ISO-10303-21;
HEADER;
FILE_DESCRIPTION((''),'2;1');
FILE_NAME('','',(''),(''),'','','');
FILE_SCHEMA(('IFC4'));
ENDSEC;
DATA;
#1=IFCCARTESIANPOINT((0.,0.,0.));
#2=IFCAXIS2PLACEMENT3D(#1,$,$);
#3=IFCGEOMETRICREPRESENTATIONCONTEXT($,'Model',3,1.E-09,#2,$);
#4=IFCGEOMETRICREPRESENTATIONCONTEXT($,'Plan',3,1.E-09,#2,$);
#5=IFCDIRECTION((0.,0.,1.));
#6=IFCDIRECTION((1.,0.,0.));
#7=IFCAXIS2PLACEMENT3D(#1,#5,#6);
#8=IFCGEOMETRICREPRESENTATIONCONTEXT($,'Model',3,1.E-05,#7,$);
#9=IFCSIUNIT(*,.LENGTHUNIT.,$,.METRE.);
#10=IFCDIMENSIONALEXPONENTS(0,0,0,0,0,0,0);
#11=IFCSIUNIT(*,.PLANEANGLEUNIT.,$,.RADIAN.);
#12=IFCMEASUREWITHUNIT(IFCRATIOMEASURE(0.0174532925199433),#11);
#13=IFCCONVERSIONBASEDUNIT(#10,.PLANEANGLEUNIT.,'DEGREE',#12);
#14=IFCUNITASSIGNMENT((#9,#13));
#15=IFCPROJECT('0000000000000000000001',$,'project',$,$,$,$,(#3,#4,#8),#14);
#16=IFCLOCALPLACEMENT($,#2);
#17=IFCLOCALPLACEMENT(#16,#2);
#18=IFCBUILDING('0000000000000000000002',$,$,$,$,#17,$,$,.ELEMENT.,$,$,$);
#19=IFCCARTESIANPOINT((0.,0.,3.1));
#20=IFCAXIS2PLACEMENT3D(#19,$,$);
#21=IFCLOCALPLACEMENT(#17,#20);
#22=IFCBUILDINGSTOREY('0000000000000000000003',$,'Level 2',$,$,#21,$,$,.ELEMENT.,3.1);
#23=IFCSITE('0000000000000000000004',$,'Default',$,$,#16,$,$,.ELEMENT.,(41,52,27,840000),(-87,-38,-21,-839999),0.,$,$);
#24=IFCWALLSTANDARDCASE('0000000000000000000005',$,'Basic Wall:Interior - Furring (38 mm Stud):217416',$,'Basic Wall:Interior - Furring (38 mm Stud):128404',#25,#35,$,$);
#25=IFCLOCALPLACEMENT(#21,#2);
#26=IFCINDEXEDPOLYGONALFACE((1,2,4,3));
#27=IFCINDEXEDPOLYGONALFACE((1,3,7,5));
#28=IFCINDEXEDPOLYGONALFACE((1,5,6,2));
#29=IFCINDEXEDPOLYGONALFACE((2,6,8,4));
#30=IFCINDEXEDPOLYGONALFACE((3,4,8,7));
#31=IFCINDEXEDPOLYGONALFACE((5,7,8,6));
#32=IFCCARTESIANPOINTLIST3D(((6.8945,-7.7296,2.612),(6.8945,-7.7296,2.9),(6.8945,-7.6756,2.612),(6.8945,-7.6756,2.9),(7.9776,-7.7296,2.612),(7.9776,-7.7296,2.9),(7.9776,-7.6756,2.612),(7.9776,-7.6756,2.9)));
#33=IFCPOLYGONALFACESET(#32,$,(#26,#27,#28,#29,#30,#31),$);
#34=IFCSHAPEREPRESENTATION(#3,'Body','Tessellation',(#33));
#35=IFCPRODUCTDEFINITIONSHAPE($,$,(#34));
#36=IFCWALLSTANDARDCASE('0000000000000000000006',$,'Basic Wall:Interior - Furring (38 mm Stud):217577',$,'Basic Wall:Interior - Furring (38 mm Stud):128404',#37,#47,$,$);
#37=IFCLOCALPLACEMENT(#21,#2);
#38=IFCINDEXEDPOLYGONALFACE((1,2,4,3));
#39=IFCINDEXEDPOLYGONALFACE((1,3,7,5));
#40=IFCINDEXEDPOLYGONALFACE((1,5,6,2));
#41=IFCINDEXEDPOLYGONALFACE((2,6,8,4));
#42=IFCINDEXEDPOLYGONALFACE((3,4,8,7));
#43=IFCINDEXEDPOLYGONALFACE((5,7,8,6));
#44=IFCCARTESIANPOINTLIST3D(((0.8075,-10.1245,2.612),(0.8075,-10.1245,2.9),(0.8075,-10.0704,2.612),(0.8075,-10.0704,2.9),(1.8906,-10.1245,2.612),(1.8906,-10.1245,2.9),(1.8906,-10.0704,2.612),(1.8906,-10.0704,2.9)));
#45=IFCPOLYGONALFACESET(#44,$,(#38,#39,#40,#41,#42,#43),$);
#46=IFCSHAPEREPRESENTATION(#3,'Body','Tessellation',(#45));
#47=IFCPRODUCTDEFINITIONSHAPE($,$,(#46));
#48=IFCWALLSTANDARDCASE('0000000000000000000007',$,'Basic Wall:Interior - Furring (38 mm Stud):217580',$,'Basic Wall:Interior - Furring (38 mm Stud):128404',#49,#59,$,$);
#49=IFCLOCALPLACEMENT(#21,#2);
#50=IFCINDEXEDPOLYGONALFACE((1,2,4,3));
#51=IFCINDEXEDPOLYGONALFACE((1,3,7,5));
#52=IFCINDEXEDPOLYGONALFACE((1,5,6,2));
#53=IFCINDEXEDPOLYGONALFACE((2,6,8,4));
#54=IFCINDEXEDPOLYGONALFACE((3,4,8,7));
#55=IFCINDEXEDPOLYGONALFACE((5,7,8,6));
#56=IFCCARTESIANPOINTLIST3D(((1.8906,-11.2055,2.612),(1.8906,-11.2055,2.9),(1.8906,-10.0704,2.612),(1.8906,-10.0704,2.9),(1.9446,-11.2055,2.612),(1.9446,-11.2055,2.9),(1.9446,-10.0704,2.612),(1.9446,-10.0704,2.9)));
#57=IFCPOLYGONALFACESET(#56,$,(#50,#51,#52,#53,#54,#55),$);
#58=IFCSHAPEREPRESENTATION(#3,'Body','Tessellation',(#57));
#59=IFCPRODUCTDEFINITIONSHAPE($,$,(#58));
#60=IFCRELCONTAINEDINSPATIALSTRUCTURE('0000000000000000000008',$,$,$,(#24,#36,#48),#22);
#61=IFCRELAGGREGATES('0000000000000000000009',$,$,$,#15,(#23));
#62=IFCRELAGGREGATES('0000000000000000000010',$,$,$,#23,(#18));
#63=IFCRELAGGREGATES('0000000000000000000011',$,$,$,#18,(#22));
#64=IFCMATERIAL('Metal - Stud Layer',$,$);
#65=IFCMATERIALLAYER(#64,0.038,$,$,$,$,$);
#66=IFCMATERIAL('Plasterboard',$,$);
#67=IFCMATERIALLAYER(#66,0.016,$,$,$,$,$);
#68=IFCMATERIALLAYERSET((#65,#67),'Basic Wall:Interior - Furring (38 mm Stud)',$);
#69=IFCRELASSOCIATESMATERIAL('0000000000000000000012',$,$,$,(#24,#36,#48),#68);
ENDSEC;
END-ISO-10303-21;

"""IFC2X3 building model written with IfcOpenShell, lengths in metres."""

from ifc_helpers import new_model, entity, si_unit, converted_unit, frame, frame_2d, origin, origin_with_axes, place, context, project, spatial, rectangle, extrude, material, layer, layer_set, layer_usage, element, save


model = new_model("IFC2X3")

# Units and contexts
model_context_1 = context("Model", 3, precision=1e-09, world=origin())
plan_context = context("Plan", 3, precision=1e-09, world=origin())
model_context_2 = context("Model", 3, precision=1e-05, world=origin_with_axes())
ifc_project = project(units=[si_unit("LENGTHUNIT", "METRE"), converted_unit("PLANEANGLEUNIT", "DEGREE", entity("IfcRatioMeasure", 0.0174532925199433), si_unit("PLANEANGLEUNIT", "RADIAN"), dimensions=[0, 0, 0, 0, 0, 0, 0])], contexts=[model_context_1, plan_context, model_context_2])

# Site, building, storey
site_placement = place(None, origin())
site = spatial("IfcSite", under=ifc_project, at=site_placement, Name="Default", CompositionType="ELEMENT", RefLatitude=(41, 52, 27, 840000), RefLongitude=(-87, -38, -21, -839999), RefElevation=0.0)
building_placement = place(site_placement, origin())
building = spatial("IfcBuilding", under=site, at=building_placement, CompositionType="ELEMENT")
storey_placement = place(building_placement, frame((0.0, 0.0, 3.1)))
storey = spatial("IfcBuildingStorey", under=building, at=storey_placement, Name="Level 2", CompositionType="ELEMENT", Elevation=3.1)

# Shared definitions
ifc_material_1 = material(Name="Plasterboard")
ifc_material_2 = material(Name="Metal - Stud Layer")

# Walls
ifc_layer_1 = layer(ifc_material_2, 0.038)
ifc_layer_2 = layer(ifc_material_1, 0.016)
ifc_layer_set_1 = layer_set([ifc_layer_1, ifc_layer_2], Name="Basic Wall:Interior - Furring (38 mm Stud)")
ifc_layer_usage_1 = layer_usage(ifc_layer_set_1, "AXIS2", "NEGATIVE", 0.027)
wall_1_placement = place(storey_placement, frame((7.9776, -7.7026, 2.612), z_axis=(0.0, 0.0, 1.0), x_axis=(-1.0, 0.0, 0.0)))
element("IfcWallStandardCase", 1, at=wall_1_placement, inside=storey, material=ifc_layer_usage_1, Name="Basic Wall:Interior - Furring (38 mm Stud):217416", ObjectType="Basic Wall:Interior - Furring (38 mm Stud):128404", context=model_context_1, shape_type="SweptSolid", body=[
    extrude(rectangle(XDim=1.0831, YDim=0.054, at=frame_2d((0.5415, 0.0), x_axis=(-1.0, 0.0))), origin(), (0.0, 0.0, 1.0), 0.288),
])
ifc_layer_usage_2 = layer_usage(ifc_layer_set_1, "AXIS2", "NEGATIVE", 0.027)
wall_2_placement = place(storey_placement, frame((0.8075, -10.0975, 2.612)))
element("IfcWallStandardCase", 2, at=wall_2_placement, inside=storey, material=ifc_layer_usage_2, Name="Basic Wall:Interior - Furring (38 mm Stud):217577", ObjectType="Basic Wall:Interior - Furring (38 mm Stud):128404", context=model_context_1, shape_type="SweptSolid", body=[
    extrude(rectangle(XDim=1.0831, YDim=0.054, at=frame_2d((0.5415, 0.0), x_axis=(-1.0, 0.0))), origin(), (0.0, 0.0, 1.0), 0.288),
])
ifc_layer_usage_3 = layer_usage(ifc_layer_set_1, "AXIS2", "NEGATIVE", 0.027)
wall_3_placement = place(storey_placement, frame((1.9176, -10.0704, 2.612), z_axis=(0.0, 0.0, 1.0), x_axis=(0.0, -1.0, 0.0)))
element("IfcWallStandardCase", 3, at=wall_3_placement, inside=storey, material=ifc_layer_usage_3, Name="Basic Wall:Interior - Furring (38 mm Stud):217580", ObjectType="Basic Wall:Interior - Furring (38 mm Stud):128404", context=model_context_1, shape_type="SweptSolid", body=[
    extrude(rectangle(XDim=1.1351, YDim=0.054, at=frame_2d((0.5675, 0.0), x_axis=(-1.0, 0.0))), origin(), (0.0, 0.0, 1.0), 0.288),
])

save(model, "model.ifc")
